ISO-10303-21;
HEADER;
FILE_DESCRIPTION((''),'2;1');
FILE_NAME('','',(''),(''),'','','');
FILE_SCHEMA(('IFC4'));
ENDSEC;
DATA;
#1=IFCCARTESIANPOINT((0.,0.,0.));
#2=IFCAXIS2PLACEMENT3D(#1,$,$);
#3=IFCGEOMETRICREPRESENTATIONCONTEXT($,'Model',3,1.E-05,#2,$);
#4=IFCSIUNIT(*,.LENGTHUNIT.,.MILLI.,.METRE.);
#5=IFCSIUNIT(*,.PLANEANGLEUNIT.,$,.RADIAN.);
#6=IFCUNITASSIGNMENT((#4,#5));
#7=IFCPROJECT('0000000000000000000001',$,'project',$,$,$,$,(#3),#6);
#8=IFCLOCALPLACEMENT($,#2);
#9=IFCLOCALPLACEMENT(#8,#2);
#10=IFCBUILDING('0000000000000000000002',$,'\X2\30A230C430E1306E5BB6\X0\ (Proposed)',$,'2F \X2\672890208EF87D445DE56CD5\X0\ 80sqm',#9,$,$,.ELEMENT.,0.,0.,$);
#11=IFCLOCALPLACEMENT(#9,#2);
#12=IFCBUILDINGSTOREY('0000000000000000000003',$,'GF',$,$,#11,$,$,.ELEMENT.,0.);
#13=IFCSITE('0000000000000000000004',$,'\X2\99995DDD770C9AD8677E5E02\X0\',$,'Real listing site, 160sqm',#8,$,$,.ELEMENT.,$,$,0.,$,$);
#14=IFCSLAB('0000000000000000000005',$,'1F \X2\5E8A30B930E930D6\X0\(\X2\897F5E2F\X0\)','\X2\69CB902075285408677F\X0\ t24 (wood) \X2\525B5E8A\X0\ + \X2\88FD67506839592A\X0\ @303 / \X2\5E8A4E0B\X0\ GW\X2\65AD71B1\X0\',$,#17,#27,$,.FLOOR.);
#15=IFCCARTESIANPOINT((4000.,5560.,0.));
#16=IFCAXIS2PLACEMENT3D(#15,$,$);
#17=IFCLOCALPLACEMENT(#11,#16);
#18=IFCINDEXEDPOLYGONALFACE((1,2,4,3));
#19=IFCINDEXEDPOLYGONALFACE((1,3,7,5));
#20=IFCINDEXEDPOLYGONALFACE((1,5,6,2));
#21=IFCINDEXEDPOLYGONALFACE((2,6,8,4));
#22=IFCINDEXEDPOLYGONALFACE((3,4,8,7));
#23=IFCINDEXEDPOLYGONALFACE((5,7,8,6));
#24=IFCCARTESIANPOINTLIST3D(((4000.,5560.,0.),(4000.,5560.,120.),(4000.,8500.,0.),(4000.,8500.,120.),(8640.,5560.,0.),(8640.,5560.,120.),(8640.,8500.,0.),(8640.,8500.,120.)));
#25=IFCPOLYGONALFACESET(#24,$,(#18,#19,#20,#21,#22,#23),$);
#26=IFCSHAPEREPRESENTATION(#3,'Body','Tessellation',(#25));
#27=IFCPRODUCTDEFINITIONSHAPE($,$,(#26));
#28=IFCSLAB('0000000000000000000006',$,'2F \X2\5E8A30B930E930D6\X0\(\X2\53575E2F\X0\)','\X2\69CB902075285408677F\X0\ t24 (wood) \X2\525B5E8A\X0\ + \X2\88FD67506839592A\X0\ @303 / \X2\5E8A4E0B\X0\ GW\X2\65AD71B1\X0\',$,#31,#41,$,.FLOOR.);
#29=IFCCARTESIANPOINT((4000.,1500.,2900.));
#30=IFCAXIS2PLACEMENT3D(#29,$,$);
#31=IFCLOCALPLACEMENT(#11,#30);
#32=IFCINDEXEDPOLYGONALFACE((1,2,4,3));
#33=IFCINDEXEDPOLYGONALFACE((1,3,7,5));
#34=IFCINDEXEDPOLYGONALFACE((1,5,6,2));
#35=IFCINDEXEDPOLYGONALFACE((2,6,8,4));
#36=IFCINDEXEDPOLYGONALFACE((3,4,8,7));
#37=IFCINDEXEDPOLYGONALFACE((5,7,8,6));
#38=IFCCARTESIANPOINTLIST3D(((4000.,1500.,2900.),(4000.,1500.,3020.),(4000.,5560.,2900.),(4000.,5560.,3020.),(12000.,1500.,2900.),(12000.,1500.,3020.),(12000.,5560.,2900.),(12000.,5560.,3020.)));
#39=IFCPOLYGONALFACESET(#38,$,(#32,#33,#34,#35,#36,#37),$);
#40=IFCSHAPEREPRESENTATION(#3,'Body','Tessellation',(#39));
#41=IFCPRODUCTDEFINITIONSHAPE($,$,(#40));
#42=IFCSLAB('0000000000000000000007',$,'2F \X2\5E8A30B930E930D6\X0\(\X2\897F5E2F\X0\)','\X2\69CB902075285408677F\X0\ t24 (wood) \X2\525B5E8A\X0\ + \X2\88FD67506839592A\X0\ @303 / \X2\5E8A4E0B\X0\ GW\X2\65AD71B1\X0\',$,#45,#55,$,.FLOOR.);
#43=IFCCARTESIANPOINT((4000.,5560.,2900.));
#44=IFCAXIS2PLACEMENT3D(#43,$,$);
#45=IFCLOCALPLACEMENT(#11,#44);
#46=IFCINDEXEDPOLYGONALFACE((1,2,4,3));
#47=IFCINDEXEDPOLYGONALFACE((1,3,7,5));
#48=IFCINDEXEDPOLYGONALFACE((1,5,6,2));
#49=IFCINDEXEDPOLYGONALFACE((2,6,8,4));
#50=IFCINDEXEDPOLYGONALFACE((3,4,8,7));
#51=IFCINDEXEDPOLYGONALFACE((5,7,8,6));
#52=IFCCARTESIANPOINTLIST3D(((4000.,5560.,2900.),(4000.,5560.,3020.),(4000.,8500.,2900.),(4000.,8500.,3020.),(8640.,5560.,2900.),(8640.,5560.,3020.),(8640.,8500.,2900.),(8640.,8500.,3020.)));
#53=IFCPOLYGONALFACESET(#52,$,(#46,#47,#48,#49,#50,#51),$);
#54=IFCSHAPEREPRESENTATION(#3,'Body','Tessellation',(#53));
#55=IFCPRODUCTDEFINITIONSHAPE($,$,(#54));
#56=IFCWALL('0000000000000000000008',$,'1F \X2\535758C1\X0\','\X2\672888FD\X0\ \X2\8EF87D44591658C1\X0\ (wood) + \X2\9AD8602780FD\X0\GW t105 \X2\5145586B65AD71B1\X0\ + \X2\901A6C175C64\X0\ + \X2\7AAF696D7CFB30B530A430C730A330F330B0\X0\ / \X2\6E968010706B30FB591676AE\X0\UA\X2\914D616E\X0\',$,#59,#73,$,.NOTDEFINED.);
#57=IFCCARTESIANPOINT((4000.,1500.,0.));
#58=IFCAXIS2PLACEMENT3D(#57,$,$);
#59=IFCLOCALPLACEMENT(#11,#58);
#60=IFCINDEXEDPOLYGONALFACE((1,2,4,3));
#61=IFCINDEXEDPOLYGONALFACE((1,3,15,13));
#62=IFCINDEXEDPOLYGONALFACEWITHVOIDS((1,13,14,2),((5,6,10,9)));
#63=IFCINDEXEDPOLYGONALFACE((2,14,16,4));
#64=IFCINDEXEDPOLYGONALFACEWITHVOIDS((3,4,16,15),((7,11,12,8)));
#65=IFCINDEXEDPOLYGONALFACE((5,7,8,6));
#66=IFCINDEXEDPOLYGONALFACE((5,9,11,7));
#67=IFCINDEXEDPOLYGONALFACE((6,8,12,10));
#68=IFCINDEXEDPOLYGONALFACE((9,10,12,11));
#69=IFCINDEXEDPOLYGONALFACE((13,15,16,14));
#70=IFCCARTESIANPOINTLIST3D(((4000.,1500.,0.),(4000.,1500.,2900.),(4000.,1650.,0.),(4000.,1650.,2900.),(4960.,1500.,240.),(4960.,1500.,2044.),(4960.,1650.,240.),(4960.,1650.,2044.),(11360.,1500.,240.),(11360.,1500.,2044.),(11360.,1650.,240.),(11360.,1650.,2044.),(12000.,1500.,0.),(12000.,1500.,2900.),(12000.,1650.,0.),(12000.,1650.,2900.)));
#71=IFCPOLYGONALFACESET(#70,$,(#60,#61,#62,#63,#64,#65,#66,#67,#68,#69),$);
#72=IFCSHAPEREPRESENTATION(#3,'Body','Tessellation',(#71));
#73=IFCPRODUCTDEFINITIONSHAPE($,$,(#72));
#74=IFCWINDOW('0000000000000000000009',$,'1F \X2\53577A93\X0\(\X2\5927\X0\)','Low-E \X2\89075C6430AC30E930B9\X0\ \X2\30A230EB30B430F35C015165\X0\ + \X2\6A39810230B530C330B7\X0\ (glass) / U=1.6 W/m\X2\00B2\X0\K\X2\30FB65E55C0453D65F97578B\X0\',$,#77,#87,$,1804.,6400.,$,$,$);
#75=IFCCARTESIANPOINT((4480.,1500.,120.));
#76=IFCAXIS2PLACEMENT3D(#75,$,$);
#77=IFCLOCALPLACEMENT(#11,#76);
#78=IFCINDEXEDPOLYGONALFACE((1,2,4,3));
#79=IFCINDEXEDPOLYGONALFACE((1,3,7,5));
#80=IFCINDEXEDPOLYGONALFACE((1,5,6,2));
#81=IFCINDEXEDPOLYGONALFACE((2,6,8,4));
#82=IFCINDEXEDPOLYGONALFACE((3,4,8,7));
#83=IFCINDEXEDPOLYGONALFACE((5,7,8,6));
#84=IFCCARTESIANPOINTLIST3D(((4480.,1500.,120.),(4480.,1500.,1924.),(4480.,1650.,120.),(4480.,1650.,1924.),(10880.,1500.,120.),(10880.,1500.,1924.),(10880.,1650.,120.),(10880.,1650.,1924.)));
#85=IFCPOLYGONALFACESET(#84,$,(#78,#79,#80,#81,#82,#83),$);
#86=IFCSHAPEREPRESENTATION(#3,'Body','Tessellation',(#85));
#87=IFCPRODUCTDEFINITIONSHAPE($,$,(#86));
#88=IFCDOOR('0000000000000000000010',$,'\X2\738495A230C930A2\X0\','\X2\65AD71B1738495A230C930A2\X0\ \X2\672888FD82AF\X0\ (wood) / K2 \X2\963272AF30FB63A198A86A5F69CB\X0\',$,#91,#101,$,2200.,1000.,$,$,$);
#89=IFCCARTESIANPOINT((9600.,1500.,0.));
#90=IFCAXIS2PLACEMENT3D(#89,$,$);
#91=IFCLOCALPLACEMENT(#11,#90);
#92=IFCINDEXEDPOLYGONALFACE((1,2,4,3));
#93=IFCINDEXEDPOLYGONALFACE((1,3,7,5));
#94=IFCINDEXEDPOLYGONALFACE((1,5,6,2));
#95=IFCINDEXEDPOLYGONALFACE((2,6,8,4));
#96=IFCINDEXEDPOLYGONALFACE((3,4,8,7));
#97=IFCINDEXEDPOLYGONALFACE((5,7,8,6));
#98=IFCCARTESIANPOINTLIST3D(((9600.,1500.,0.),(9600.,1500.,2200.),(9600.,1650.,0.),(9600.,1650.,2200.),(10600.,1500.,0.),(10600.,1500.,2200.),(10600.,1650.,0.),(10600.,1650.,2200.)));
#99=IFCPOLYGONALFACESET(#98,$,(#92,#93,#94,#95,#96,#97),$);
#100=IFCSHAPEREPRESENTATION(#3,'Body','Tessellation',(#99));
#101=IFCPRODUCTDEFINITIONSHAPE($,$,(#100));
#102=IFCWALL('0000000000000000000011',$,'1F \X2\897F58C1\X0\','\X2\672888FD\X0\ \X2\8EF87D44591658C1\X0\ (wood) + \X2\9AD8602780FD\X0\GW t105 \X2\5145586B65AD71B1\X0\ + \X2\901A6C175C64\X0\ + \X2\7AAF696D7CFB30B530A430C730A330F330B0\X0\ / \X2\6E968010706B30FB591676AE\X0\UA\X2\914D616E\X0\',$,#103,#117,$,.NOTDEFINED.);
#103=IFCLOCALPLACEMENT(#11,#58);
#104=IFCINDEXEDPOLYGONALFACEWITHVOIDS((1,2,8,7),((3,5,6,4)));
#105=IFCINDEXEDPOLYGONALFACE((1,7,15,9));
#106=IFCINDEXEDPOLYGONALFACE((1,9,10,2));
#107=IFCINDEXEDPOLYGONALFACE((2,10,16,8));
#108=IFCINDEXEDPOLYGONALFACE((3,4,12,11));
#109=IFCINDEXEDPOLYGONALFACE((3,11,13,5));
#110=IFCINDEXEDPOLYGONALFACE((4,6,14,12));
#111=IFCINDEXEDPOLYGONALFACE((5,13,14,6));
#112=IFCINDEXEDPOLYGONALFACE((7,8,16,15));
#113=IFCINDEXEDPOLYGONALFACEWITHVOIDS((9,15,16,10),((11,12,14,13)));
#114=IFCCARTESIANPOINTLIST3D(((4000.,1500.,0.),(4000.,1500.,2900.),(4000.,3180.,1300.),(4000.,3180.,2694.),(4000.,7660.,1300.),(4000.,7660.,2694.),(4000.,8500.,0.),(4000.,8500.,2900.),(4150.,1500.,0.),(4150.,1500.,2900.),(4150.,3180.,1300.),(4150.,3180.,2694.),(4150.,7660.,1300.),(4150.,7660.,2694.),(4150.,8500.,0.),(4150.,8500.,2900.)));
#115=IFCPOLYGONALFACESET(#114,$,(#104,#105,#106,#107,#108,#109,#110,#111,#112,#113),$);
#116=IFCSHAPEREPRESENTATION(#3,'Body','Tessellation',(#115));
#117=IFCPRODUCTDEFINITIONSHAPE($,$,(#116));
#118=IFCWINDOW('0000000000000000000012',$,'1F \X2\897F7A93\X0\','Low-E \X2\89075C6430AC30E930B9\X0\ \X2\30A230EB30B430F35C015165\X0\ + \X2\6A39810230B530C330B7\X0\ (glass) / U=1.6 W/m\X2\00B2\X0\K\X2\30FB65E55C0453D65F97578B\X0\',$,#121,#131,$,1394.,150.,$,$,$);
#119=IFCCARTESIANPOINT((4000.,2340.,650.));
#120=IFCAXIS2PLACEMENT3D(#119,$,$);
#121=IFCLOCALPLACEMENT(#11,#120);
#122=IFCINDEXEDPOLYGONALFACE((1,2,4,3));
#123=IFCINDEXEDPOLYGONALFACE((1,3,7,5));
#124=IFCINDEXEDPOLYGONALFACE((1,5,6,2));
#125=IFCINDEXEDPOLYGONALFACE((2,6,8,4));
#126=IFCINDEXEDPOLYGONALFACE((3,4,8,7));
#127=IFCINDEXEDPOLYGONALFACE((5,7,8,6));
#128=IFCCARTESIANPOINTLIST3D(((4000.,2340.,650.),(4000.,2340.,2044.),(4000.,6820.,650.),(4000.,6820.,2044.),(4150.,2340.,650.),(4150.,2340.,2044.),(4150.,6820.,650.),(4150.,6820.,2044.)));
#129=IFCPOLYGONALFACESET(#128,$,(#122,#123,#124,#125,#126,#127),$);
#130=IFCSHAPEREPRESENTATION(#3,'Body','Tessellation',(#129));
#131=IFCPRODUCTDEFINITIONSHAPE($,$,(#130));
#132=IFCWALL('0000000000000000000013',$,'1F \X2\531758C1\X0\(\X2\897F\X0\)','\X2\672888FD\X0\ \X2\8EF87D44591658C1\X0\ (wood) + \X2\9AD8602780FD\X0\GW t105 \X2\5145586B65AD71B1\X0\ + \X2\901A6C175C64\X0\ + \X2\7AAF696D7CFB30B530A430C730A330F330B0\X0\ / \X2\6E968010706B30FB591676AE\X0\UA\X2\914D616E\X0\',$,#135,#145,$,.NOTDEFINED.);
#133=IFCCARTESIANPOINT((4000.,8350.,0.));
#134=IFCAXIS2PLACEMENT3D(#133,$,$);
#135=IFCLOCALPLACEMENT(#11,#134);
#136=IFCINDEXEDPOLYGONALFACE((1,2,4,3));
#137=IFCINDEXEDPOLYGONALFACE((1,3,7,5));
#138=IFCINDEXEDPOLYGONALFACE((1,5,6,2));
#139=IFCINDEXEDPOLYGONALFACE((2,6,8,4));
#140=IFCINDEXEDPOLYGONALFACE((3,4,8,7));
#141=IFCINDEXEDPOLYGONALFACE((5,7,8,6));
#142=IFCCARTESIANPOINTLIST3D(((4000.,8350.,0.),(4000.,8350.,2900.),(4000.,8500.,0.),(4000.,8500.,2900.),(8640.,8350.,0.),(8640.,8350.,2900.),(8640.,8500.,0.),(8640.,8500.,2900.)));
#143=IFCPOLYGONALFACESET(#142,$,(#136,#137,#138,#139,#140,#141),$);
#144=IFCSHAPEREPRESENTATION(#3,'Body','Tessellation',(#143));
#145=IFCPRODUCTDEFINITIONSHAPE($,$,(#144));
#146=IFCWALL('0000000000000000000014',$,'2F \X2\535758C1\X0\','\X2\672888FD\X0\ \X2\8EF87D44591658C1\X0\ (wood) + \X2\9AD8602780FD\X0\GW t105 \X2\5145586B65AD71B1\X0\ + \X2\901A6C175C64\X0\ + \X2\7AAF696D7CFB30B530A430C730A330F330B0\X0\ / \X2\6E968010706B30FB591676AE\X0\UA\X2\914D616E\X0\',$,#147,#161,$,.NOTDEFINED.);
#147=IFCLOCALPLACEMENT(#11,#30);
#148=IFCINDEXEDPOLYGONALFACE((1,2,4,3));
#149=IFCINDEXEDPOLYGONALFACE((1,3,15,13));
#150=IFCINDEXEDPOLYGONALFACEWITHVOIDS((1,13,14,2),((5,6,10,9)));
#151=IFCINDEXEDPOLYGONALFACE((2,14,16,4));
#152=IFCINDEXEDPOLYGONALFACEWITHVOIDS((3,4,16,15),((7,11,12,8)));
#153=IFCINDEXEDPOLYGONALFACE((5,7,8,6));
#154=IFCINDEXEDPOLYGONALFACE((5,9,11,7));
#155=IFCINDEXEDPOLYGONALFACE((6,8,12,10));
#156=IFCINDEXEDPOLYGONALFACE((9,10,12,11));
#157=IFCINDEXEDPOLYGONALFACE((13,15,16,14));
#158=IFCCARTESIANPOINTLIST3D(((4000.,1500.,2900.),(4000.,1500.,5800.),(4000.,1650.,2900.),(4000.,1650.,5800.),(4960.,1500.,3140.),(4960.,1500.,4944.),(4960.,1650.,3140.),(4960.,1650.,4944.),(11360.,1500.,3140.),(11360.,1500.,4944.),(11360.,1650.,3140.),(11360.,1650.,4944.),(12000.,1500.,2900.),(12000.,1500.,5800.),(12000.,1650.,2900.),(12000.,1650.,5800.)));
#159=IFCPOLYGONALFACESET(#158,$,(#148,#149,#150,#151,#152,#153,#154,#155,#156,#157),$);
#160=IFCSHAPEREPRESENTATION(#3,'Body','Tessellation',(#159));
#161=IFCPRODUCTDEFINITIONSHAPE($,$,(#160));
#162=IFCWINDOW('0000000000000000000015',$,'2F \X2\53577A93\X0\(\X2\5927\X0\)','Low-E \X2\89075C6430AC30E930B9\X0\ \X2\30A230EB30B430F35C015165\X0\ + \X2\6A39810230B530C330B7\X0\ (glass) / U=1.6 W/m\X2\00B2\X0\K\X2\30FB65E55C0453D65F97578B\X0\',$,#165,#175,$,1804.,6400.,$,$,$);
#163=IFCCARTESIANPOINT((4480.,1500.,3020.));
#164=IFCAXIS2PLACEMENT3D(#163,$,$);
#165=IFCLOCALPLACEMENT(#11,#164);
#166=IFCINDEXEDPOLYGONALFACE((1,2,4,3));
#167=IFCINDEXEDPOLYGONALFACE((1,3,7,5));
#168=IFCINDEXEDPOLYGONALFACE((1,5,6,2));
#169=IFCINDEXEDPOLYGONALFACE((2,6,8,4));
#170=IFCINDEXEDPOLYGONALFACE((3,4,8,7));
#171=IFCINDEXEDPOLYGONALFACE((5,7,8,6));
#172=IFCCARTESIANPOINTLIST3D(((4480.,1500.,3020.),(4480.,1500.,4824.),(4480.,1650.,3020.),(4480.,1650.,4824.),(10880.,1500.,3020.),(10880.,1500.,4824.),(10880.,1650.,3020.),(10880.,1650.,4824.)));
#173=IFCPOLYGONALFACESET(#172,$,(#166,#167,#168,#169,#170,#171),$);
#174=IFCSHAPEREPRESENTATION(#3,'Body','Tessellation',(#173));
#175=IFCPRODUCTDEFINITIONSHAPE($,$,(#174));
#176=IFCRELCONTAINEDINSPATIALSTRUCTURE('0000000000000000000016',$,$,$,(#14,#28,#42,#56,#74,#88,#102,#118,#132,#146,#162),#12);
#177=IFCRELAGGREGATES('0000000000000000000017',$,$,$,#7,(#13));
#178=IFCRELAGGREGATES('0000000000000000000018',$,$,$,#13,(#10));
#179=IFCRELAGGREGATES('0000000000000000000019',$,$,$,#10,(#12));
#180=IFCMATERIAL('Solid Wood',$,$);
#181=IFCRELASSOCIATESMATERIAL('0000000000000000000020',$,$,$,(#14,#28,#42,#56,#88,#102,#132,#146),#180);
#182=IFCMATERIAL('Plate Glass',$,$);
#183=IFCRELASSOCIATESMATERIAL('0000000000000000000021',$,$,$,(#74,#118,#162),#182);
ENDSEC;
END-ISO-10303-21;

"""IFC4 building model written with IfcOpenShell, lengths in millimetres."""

from ifc_helpers import new_model, si_unit, frame, frame_2d, origin, place, context, project, spatial, rectangle, extrude, material, element, fill, save


model = new_model("IFC4")

# Units and contexts
model_context = context("Model", 3, precision=1e-05, world=origin())
ifc_project = project(units=[si_unit("LENGTHUNIT", "METRE", prefix="MILLI"), si_unit("PLANEANGLEUNIT", "RADIAN")], contexts=[model_context])

# Site, building, storey
site_placement = place(None, origin())
site = spatial("IfcSite", under=ifc_project, at=site_placement, Name="香川県高松市", ObjectType="Real listing site, 160sqm", CompositionType="ELEMENT", RefElevation=0.0)
building_placement = place(site_placement, origin())
building = spatial("IfcBuilding", under=site, at=building_placement, Name="アツメの家 (Proposed)", ObjectType="2F 木造軸組工法 80sqm", CompositionType="ELEMENT", ElevationOfRefHeight=0.0, ElevationOfTerrain=0.0)
storey_placement = place(building_placement, origin())
storey = spatial("IfcBuildingStorey", under=building, at=storey_placement, Name="GF", CompositionType="ELEMENT", Elevation=0.0)

# Slabs
ifc_material_1 = material(Name="Solid Wood")
slab_1_placement = place(storey_placement, frame((4000.0, 5560.0, 0.0)))
element("IfcSlab", 1, at=slab_1_placement, inside=storey, material=ifc_material_1, Name="1F 床スラブ(西帯)", Description="構造用合板 t24 (wood) 剛床 + 製材根太 @303 / 床下 GW断熱", PredefinedType="FLOOR", context=model_context, shape_type="SweptSolid", body=[
    extrude(rectangle(XDim=4640.0, YDim=2940.0, at=frame_2d((2320.0, 1470.0))), frame((4000.0, 5560.0, 0.0)), (0.0, 0.0, 1.0), 120.0),
])
slab_2_placement = place(storey_placement, frame((4000.0, 1500.0, 2900.0)))
element("IfcSlab", 2, at=slab_2_placement, inside=storey, material=ifc_material_1, Name="2F 床スラブ(南帯)", Description="構造用合板 t24 (wood) 剛床 + 製材根太 @303 / 床下 GW断熱", PredefinedType="FLOOR", context=model_context, shape_type="SweptSolid", body=[
    extrude(rectangle(XDim=8000.0, YDim=4060.0, at=frame_2d((4000.0, 2030.0))), frame((4000.0, 1500.0, 2900.0)), (0.0, 0.0, 1.0), 120.0),
])
slab_3_placement = place(storey_placement, frame((4000.0, 5560.0, 2900.0)))
element("IfcSlab", 3, at=slab_3_placement, inside=storey, material=ifc_material_1, Name="2F 床スラブ(西帯)", Description="構造用合板 t24 (wood) 剛床 + 製材根太 @303 / 床下 GW断熱", PredefinedType="FLOOR", context=model_context, shape_type="SweptSolid", body=[
    extrude(rectangle(XDim=4640.0, YDim=2940.0, at=frame_2d((2320.0, 1470.0))), frame((4000.0, 5560.0, 2900.0)), (0.0, 0.0, 1.0), 120.0),
])

# Wall, openings, window, door
wall_1_placement = place(storey_placement, frame((4000.0, 1500.0, 0.0)))
wall_1 = element("IfcWall", 4, at=wall_1_placement, inside=storey, material=ifc_material_1, Name="1F 南壁", Description="木製 軸組外壁 (wood) + 高性能GW t105 充填断熱 + 通気層 + 窯業系サイディング / 準耐火・外皮UA配慮", PredefinedType="NOTDEFINED", context=model_context, shape_type="SweptSolid", body=[
    extrude(rectangle(XDim=8000.0, YDim=150.0, at=frame_2d((4000.0, 75.0))), frame((4000.0, 1500.0, 0.0)), (0.0, 0.0, 1.0), 2900.0),
])
opening_1_placement = place(storey_placement, frame((4480.0, 1500.0, 120.0)))
opening_1 = element("IfcOpeningElement", 5, at=opening_1_placement, cuts=wall_1, PredefinedType="NOTDEFINED", context=model_context, shape_type="SweptSolid", body=[
    extrude(rectangle(XDim=6400.0, YDim=150.0, at=frame_2d((3200.0, 75.0))), frame((4480.0, 1500.0, 120.0)), (0.0, 0.0, 1.0), 1804.0),
])
opening_2_placement = place(storey_placement, frame((9600.0, 1500.0, 0.0)))
opening_2 = element("IfcOpeningElement", 6, at=opening_2_placement, cuts=wall_1, PredefinedType="NOTDEFINED", context=model_context, shape_type="SweptSolid", body=[
    extrude(rectangle(XDim=1000.0, YDim=150.0, at=frame_2d((500.0, 75.0))), frame((9600.0, 1500.0, 0.0)), (0.0, 0.0, 1.0), 2200.0),
])
ifc_material_2 = material(Name="Plate Glass")
window_1_placement = place(storey_placement, frame((4480.0, 1500.0, 120.0)))
window_1 = element("IfcWindow", 7, at=window_1_placement, inside=storey, material=ifc_material_2, Name="1F 南窓(大)", Description="Low-E 複層ガラス アルゴン封入 + 樹脂サッシ (glass) / U=1.6 W/m²K・日射取得型", OverallHeight=1804.0, OverallWidth=6400.0, context=model_context, shape_type="SweptSolid", body=[
    extrude(rectangle(XDim=6400.0, YDim=150.0, at=frame_2d((3200.0, 75.0))), frame((4480.0, 1500.0, 120.0)), (0.0, 0.0, 1.0), 1804.0),
])
fill(opening_1, window_1)
door_placement = place(storey_placement, frame((9600.0, 1500.0, 0.0)))
door = element("IfcDoor", 8, at=door_placement, inside=storey, material=ifc_material_1, Name="玄関ドア", Description="断熱玄関ドア 木製芯 (wood) / K2 防犯・採風機構", OverallHeight=2200.0, OverallWidth=1000.0, context=model_context, shape_type="SweptSolid", body=[
    extrude(rectangle(XDim=1000.0, YDim=150.0, at=frame_2d((500.0, 75.0))), frame((9600.0, 1500.0, 0.0)), (0.0, 0.0, 1.0), 2200.0),
])
fill(opening_2, door)

# Wall, opening, window
wall_2_placement = place(storey_placement, frame((4000.0, 1500.0, 0.0)))
wall_2 = element("IfcWall", 9, at=wall_2_placement, inside=storey, material=ifc_material_1, Name="1F 西壁", Description="木製 軸組外壁 (wood) + 高性能GW t105 充填断熱 + 通気層 + 窯業系サイディング / 準耐火・外皮UA配慮", PredefinedType="NOTDEFINED", context=model_context, shape_type="SweptSolid", body=[
    extrude(rectangle(XDim=150.0, YDim=7000.0, at=frame_2d((75.0, 3500.0))), frame((4000.0, 1500.0, 0.0)), (0.0, 0.0, 1.0), 2900.0),
])
opening_3_placement = place(storey_placement, frame((4000.0, 2340.0, 650.0)))
opening_3 = element("IfcOpeningElement", 10, at=opening_3_placement, cuts=wall_2, PredefinedType="NOTDEFINED", context=model_context, shape_type="SweptSolid", body=[
    extrude(rectangle(XDim=150.0, YDim=4480.0, at=frame_2d((75.0, 2240.0))), frame((4000.0, 2340.0, 650.0)), (0.0, 0.0, 1.0), 1394.0),
])
window_2_placement = place(storey_placement, frame((4000.0, 2340.0, 650.0)))
window_2 = element("IfcWindow", 11, at=window_2_placement, inside=storey, material=ifc_material_2, Name="1F 西窓", Description="Low-E 複層ガラス アルゴン封入 + 樹脂サッシ (glass) / U=1.6 W/m²K・日射取得型", OverallHeight=1394.0, OverallWidth=150.0, context=model_context, shape_type="SweptSolid", body=[
    extrude(rectangle(XDim=150.0, YDim=4480.0, at=frame_2d((75.0, 2240.0))), frame((4000.0, 2340.0, 650.0)), (0.0, 0.0, 1.0), 1394.0),
])
fill(opening_3, window_2)

# Wall
wall_3_placement = place(storey_placement, frame((4000.0, 8350.0, 0.0)))
element("IfcWall", 12, at=wall_3_placement, inside=storey, material=ifc_material_1, Name="1F 北壁(西)", Description="木製 軸組外壁 (wood) + 高性能GW t105 充填断熱 + 通気層 + 窯業系サイディング / 準耐火・外皮UA配慮", PredefinedType="NOTDEFINED", context=model_context, shape_type="SweptSolid", body=[
    extrude(rectangle(XDim=4640.0, YDim=150.0, at=frame_2d((2320.0, 75.0))), frame((4000.0, 8350.0, 0.0)), (0.0, 0.0, 1.0), 2900.0),
])

# Wall, opening, window
wall_4_placement = place(storey_placement, frame((4000.0, 1500.0, 2900.0)))
wall_4 = element("IfcWall", 13, at=wall_4_placement, inside=storey, material=ifc_material_1, Name="2F 南壁", Description="木製 軸組外壁 (wood) + 高性能GW t105 充填断熱 + 通気層 + 窯業系サイディング / 準耐火・外皮UA配慮", PredefinedType="NOTDEFINED", context=model_context, shape_type="SweptSolid", body=[
    extrude(rectangle(XDim=8000.0, YDim=150.0, at=frame_2d((4000.0, 75.0))), frame((4000.0, 1500.0, 2900.0)), (0.0, 0.0, 1.0), 2900.0),
])
opening_4_placement = place(storey_placement, frame((4480.0, 1500.0, 3020.0)))
opening_4 = element("IfcOpeningElement", 14, at=opening_4_placement, cuts=wall_4, PredefinedType="NOTDEFINED", context=model_context, shape_type="SweptSolid", body=[
    extrude(rectangle(XDim=6400.0, YDim=150.0, at=frame_2d((3200.0, 75.0))), frame((4480.0, 1500.0, 3020.0)), (0.0, 0.0, 1.0), 1804.0),
])
window_3_placement = place(storey_placement, frame((4480.0, 1500.0, 3020.0)))
window_3 = element("IfcWindow", 15, at=window_3_placement, inside=storey, material=ifc_material_2, Name="2F 南窓(大)", Description="Low-E 複層ガラス アルゴン封入 + 樹脂サッシ (glass) / U=1.6 W/m²K・日射取得型", OverallHeight=1804.0, OverallWidth=6400.0, context=model_context, shape_type="SweptSolid", body=[
    extrude(rectangle(XDim=6400.0, YDim=150.0, at=frame_2d((3200.0, 75.0))), frame((4480.0, 1500.0, 3020.0)), (0.0, 0.0, 1.0), 1804.0),
])
fill(opening_4, window_3)

save(model, "model.ifc")
